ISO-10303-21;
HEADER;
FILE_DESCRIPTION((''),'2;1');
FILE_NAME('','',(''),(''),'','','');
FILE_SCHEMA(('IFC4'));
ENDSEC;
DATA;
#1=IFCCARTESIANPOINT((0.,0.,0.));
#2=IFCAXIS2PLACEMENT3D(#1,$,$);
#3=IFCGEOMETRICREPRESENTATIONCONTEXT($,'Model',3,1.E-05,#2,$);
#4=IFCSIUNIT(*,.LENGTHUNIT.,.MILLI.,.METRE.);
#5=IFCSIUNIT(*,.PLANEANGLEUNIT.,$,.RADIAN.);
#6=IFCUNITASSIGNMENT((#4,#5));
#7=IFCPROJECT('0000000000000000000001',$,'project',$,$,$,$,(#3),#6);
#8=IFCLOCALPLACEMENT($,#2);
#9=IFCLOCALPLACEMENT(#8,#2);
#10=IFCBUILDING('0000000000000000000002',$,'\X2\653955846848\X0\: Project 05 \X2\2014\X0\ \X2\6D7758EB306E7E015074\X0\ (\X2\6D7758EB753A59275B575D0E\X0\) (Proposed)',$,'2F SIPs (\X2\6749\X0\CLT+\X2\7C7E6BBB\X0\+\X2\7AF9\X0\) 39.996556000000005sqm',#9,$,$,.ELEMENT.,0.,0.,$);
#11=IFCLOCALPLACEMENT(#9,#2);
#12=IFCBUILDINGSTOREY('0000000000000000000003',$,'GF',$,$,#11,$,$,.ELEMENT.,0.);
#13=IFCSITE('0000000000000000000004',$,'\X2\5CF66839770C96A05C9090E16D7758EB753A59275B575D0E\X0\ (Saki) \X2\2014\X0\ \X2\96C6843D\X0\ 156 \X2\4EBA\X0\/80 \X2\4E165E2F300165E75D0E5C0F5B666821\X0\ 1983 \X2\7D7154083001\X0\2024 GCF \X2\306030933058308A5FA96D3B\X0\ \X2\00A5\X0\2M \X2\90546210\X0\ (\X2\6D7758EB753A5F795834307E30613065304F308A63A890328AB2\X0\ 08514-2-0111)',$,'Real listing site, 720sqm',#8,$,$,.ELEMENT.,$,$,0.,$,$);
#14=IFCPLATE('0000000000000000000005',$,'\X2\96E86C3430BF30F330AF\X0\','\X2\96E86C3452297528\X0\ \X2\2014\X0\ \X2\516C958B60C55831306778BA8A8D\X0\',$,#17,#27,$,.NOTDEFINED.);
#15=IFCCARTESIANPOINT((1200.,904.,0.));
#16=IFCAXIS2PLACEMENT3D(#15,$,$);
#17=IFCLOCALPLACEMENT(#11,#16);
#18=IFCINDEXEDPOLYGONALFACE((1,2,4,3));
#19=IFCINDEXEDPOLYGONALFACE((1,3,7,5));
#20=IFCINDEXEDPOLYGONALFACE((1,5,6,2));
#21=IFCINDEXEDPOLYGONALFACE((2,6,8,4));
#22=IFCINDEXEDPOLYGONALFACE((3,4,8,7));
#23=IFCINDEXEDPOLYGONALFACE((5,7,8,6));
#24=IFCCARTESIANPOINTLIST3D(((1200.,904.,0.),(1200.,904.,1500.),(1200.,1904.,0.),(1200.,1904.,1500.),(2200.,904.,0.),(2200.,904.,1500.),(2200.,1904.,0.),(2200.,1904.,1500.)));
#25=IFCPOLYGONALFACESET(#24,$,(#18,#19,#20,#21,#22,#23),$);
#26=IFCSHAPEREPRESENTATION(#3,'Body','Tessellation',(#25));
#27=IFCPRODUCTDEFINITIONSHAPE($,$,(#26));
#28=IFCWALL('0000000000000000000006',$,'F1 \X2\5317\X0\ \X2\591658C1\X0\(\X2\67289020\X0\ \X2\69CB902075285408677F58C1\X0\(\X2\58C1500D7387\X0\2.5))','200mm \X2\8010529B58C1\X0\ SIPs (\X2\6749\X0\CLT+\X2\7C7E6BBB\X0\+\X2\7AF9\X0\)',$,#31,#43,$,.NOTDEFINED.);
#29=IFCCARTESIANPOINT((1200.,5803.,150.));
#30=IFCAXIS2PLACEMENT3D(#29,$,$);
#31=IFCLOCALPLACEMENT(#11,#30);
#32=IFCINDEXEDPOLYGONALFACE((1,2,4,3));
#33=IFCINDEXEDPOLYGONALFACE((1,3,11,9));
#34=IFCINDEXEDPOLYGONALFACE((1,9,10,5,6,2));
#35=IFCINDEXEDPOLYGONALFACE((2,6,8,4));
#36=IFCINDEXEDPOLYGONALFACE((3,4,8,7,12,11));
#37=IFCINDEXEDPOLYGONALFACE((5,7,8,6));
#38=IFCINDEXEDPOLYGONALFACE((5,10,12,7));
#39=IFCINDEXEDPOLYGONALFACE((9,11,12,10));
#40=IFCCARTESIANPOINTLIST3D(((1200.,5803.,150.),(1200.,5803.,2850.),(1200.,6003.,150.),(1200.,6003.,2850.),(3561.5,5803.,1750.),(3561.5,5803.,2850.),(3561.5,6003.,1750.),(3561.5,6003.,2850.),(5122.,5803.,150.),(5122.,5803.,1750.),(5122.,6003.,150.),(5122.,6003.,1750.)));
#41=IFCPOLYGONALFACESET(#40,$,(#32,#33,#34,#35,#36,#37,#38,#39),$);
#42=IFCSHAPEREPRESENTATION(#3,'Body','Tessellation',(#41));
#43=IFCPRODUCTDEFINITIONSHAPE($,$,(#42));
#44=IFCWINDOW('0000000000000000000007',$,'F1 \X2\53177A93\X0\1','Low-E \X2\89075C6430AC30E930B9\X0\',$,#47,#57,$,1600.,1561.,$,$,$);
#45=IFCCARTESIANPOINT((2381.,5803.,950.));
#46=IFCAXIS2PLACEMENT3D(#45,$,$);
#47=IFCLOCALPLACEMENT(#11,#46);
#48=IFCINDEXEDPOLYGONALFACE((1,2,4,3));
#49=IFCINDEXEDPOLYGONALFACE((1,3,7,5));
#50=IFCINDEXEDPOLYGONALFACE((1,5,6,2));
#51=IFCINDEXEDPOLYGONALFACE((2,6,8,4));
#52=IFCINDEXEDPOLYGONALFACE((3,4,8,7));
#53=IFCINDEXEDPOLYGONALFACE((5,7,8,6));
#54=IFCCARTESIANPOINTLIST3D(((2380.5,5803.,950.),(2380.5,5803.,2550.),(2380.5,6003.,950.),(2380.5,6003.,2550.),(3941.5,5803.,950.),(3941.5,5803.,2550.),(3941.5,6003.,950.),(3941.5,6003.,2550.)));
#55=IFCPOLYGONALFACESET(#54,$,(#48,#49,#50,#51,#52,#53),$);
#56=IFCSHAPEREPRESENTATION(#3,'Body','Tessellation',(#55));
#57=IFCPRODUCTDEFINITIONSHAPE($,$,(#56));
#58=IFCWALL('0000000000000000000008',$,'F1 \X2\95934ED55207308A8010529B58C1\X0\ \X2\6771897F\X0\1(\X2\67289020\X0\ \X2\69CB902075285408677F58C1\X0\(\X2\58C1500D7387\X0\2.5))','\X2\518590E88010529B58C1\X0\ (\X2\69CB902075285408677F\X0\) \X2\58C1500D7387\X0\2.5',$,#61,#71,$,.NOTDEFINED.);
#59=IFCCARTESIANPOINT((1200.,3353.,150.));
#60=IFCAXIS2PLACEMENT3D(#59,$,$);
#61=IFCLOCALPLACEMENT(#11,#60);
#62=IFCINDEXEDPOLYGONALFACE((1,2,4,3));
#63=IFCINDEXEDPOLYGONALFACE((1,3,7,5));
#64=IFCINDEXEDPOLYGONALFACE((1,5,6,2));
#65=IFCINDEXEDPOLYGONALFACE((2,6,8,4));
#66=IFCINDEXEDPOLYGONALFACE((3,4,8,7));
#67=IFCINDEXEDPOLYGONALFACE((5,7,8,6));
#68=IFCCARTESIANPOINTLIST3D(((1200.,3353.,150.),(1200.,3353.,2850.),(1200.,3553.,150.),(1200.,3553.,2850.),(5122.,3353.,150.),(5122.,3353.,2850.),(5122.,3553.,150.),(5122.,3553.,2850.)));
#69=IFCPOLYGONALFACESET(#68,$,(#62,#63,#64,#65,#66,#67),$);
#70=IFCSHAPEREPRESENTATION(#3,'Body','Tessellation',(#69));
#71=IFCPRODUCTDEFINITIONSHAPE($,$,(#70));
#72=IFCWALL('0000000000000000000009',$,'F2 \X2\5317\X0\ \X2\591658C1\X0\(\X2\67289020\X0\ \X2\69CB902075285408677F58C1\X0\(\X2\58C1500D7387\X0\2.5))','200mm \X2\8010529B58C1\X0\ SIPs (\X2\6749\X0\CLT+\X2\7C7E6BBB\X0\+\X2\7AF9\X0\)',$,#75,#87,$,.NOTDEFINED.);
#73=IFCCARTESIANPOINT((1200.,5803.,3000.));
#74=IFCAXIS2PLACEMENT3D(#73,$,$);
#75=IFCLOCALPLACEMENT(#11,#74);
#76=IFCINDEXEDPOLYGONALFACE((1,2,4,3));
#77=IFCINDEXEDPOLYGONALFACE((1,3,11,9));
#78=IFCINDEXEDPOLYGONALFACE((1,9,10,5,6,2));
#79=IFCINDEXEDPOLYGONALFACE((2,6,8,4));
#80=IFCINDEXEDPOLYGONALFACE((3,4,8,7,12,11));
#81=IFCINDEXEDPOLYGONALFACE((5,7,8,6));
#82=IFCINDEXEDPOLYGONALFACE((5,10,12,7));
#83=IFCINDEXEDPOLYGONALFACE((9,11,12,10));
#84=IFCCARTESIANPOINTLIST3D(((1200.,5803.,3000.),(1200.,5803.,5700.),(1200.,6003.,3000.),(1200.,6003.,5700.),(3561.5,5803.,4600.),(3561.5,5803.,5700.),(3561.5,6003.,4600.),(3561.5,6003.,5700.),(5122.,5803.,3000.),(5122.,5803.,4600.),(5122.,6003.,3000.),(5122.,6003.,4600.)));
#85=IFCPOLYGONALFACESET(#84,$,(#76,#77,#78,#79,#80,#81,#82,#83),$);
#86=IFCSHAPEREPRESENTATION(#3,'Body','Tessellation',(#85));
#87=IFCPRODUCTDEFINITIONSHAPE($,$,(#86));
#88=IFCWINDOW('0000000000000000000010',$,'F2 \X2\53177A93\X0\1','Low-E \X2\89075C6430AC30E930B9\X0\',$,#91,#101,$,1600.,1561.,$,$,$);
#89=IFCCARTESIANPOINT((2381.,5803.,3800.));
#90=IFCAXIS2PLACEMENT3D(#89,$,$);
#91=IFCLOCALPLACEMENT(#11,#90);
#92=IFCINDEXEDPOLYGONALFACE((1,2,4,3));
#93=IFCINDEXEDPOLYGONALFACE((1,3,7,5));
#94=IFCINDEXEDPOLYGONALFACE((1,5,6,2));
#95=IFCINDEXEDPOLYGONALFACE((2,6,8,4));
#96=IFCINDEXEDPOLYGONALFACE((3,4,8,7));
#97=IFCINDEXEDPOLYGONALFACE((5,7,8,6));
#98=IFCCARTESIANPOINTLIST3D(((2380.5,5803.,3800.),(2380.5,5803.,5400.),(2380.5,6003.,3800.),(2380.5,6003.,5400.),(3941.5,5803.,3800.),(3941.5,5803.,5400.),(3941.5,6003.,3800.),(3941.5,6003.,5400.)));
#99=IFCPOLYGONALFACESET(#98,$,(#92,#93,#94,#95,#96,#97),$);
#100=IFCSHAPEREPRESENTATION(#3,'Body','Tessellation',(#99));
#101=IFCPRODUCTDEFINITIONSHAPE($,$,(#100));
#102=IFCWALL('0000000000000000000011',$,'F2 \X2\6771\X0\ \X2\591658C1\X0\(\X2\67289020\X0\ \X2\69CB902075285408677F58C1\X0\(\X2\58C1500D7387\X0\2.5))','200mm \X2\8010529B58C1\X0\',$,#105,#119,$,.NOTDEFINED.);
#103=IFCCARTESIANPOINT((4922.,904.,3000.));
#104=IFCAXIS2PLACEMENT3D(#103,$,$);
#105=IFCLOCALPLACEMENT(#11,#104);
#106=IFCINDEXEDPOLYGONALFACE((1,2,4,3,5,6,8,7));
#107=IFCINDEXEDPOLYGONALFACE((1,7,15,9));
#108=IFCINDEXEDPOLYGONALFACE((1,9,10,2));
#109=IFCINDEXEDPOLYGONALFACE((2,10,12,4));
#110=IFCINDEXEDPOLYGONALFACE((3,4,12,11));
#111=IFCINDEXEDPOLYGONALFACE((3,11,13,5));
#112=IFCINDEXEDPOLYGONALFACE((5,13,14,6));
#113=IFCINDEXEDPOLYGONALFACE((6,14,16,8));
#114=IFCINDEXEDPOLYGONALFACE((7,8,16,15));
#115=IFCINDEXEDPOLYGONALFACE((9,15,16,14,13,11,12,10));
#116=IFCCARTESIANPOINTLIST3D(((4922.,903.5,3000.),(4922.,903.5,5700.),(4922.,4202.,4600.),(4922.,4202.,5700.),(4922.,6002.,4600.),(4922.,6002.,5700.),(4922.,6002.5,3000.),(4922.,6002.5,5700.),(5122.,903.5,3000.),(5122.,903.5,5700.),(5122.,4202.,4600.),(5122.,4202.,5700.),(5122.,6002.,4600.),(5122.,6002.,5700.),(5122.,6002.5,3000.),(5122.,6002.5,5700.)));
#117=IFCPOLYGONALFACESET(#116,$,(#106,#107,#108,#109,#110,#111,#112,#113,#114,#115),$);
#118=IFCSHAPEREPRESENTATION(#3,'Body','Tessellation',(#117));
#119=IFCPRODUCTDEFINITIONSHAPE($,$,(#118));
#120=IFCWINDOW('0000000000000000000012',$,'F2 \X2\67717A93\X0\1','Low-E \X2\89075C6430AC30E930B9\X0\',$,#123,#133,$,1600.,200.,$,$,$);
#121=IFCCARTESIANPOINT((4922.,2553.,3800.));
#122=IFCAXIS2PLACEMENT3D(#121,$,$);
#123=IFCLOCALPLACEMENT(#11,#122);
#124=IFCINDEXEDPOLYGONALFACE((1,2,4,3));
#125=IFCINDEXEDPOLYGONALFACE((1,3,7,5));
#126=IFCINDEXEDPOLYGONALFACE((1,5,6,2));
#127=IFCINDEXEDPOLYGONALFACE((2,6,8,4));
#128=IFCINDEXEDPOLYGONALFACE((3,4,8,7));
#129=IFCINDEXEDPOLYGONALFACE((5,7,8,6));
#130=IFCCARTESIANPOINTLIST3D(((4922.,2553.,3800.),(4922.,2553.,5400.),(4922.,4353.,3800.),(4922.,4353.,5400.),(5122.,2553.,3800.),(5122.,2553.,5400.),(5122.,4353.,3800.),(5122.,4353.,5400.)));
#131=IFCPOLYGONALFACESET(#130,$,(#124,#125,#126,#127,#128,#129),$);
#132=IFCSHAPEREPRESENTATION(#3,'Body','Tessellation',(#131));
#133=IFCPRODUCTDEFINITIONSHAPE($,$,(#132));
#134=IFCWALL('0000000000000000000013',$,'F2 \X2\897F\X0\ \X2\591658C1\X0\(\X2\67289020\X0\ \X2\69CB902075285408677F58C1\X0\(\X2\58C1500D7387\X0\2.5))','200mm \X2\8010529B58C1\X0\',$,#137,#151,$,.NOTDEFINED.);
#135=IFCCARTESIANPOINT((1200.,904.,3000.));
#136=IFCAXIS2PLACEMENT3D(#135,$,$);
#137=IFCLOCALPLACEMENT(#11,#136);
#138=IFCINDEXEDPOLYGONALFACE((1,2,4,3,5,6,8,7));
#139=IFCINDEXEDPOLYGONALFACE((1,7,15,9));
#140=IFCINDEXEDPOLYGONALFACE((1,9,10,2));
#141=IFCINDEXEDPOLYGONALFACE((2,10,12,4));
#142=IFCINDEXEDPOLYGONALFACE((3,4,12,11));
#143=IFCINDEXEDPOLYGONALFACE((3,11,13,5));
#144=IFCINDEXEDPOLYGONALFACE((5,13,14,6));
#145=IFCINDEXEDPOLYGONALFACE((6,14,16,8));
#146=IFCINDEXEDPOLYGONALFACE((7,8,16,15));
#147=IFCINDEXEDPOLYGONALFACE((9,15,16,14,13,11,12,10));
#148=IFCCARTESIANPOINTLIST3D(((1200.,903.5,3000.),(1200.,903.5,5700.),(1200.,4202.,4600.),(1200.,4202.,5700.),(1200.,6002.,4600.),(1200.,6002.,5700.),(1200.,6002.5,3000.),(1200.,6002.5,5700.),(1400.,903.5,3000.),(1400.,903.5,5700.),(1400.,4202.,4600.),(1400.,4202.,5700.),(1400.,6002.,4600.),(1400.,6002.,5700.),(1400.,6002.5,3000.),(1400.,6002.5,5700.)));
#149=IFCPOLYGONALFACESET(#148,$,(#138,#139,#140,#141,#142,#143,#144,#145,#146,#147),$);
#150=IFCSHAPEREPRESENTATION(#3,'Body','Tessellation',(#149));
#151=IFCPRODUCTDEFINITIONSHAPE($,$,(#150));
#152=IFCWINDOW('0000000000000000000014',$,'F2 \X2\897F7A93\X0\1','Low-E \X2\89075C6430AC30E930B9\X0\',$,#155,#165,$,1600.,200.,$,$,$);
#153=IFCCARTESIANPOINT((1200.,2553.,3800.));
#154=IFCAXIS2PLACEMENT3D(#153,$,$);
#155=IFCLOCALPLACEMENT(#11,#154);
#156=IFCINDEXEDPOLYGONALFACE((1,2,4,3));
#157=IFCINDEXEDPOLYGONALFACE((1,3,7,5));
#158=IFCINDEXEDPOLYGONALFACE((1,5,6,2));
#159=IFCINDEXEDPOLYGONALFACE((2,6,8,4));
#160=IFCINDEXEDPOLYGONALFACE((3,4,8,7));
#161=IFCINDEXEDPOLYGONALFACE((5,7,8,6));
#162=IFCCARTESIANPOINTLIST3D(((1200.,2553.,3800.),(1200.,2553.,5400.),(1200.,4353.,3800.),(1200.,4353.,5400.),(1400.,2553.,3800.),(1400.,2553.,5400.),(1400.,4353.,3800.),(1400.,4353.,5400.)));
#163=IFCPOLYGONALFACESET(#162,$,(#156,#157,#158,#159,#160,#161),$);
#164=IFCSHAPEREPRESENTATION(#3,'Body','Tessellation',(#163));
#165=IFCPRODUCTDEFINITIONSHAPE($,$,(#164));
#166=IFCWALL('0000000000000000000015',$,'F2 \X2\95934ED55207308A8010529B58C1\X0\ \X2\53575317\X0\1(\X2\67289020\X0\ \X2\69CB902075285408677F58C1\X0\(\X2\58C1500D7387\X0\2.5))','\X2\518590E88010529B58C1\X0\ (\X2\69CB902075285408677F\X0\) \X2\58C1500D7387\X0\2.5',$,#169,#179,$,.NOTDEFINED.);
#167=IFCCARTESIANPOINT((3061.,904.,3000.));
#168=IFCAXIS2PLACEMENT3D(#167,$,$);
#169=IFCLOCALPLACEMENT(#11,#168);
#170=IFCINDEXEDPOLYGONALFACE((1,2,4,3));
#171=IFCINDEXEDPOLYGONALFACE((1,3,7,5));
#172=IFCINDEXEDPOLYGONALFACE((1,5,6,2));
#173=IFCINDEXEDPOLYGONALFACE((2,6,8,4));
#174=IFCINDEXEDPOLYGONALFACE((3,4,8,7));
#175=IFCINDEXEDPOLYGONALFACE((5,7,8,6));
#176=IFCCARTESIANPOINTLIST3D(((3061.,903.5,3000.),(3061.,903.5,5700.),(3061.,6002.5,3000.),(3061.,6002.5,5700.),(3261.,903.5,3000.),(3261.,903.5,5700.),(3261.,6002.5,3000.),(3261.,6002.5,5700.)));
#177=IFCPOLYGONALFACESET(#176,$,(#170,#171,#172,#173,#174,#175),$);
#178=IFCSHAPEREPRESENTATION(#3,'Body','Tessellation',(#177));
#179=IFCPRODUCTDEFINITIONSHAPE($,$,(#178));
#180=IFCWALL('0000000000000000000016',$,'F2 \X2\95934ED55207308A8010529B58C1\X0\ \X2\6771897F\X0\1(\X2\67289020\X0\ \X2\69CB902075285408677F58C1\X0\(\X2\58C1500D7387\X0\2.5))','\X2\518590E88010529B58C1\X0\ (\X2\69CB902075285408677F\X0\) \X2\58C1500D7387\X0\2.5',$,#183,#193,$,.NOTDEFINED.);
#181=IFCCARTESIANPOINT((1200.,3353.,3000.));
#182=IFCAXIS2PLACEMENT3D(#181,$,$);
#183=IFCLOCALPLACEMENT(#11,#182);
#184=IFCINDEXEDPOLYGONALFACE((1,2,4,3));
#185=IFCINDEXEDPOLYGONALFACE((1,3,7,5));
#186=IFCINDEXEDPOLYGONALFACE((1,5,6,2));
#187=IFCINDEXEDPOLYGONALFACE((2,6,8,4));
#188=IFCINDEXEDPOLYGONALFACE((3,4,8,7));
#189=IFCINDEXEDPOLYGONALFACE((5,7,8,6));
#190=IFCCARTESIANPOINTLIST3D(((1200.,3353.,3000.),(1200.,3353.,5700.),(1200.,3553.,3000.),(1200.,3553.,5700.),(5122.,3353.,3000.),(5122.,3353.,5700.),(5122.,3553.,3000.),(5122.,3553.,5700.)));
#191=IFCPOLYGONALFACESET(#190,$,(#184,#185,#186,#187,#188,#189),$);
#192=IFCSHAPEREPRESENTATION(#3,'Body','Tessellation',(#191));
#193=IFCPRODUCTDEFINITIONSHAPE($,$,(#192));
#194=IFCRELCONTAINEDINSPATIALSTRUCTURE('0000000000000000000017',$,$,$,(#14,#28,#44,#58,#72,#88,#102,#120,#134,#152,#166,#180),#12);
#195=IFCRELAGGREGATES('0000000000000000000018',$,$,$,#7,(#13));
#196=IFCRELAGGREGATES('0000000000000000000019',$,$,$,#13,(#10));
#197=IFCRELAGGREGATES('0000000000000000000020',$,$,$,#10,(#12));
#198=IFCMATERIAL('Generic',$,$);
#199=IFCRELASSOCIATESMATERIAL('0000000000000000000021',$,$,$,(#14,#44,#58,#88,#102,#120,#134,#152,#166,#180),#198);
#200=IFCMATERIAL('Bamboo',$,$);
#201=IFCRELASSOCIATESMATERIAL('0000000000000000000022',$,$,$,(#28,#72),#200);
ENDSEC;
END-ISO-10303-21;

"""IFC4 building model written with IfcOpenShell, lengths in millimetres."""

from ifc_helpers import new_model, si_unit, frame, frame_2d, origin, place, context, project, spatial, rectangle, extrude, material, element, fill, save


model = new_model("IFC4")

# Units and contexts
model_context = context("Model", 3, precision=1e-05, world=origin())
ifc_project = project(units=[si_unit("LENGTHUNIT", "METRE", prefix="MILLI"), si_unit("PLANEANGLEUNIT", "RADIAN")], contexts=[model_context])

# Site, building, storey
site_placement = place(None, origin())
site = spatial("IfcSite", under=ifc_project, at=site_placement, Name="島根県隠岐郡海士町大字崎 (Saki) — 集落 156 人/80 世帯、旧崎小学校 1983 統合、2024 GCF だんじり復活 ¥2M 達成 (海士町役場まちづくり推進課 08514-2-0111)", ObjectType="Real listing site, 720sqm", CompositionType="ELEMENT", RefElevation=0.0)
building_placement = place(site_placement, origin())
building = spatial("IfcBuilding", under=site, at=building_placement, Name="改善案: Project 05 — 海士の縁側 (海士町大字崎) (Proposed)", ObjectType="2F SIPs (杉CLT+籾殻+竹) 39.996556000000005sqm", CompositionType="ELEMENT", ElevationOfRefHeight=0.0, ElevationOfTerrain=0.0)
storey_placement = place(building_placement, origin())
storey = spatial("IfcBuildingStorey", under=building, at=storey_placement, Name="GF", CompositionType="ELEMENT", Elevation=0.0)

# Plate
ifc_material_1 = material(Name="Generic")
plate_placement = place(storey_placement, frame((1200.0, 904.0, 0.0)))
element("IfcPlate", 1, at=plate_placement, inside=storey, material=ifc_material_1, Name="雨水タンク", Description="雨水利用 — 公開情報で確認", PredefinedType="NOTDEFINED", context=model_context, shape_type="SweptSolid", body=[
    extrude(rectangle(XDim=1000.0, YDim=1000.0, at=frame_2d((500.0, 500.0))), frame((1200.0, 904.0, 0.0)), (0.0, 0.0, 1.0), 1500.0),
])

# Wall, opening, window
ifc_material_2 = material(Name="Bamboo")
wall_1_placement = place(storey_placement, frame((1200.0, 5803.0, 150.0)))
wall_1 = element("IfcWall", 2, at=wall_1_placement, inside=storey, material=ifc_material_2, Name="F1 北 外壁(木造 構造用合板壁(壁倍率2.5))", Description="200mm 耐力壁 SIPs (杉CLT+籾殻+竹)", PredefinedType="NOTDEFINED", context=model_context, shape_type="SweptSolid", body=[
    extrude(rectangle(XDim=3922.0, YDim=200.0, at=frame_2d((1961.0, 100.0))), frame((1200.0, 5803.0, 150.0)), (0.0, 0.0, 1.0), 2700.0),
])
opening_1_placement = place(storey_placement, frame((2381.0, 5803.0, 950.0)))
opening_1 = element("IfcOpeningElement", 3, at=opening_1_placement, cuts=wall_1, PredefinedType="NOTDEFINED", context=model_context, shape_type="SweptSolid", body=[
    extrude(rectangle(XDim=1561.0, YDim=200.0, at=frame_2d((780.0, 100.0))), frame((2381.0, 5803.0, 950.0)), (0.0, 0.0, 1.0), 1600.0),
])
window_1_placement = place(storey_placement, frame((2381.0, 5803.0, 950.0)))
window_1 = element("IfcWindow", 4, at=window_1_placement, inside=storey, material=ifc_material_1, Name="F1 北窓1", Description="Low-E 複層ガラス", OverallHeight=1600.0, OverallWidth=1561.0, context=model_context, shape_type="SweptSolid", body=[
    extrude(rectangle(XDim=1561.0, YDim=200.0, at=frame_2d((780.0, 100.0))), frame((2381.0, 5803.0, 950.0)), (0.0, 0.0, 1.0), 1600.0),
])
fill(opening_1, window_1)

# Wall
wall_2_placement = place(storey_placement, frame((1200.0, 3353.0, 150.0)))
element("IfcWall", 5, at=wall_2_placement, inside=storey, material=ifc_material_1, Name="F1 間仕切り耐力壁 東西1(木造 構造用合板壁(壁倍率2.5))", Description="内部耐力壁 (構造用合板) 壁倍率2.5", PredefinedType="NOTDEFINED", context=model_context, shape_type="SweptSolid", body=[
    extrude(rectangle(XDim=3922.0, YDim=200.0, at=frame_2d((1961.0, 100.0))), frame((1200.0, 3353.0, 150.0)), (0.0, 0.0, 1.0), 2700.0),
])

# Walls, openings, windows
wall_3_placement = place(storey_placement, frame((1200.0, 5803.0, 3000.0)))
wall_3 = element("IfcWall", 6, at=wall_3_placement, inside=storey, material=ifc_material_2, Name="F2 北 外壁(木造 構造用合板壁(壁倍率2.5))", Description="200mm 耐力壁 SIPs (杉CLT+籾殻+竹)", PredefinedType="NOTDEFINED", context=model_context, shape_type="SweptSolid", body=[
    extrude(rectangle(XDim=3922.0, YDim=200.0, at=frame_2d((1961.0, 100.0))), frame((1200.0, 5803.0, 3000.0)), (0.0, 0.0, 1.0), 2700.0),
])
opening_2_placement = place(storey_placement, frame((2381.0, 5803.0, 3800.0)))
opening_2 = element("IfcOpeningElement", 7, at=opening_2_placement, cuts=wall_3, PredefinedType="NOTDEFINED", context=model_context, shape_type="SweptSolid", body=[
    extrude(rectangle(XDim=1561.0, YDim=200.0, at=frame_2d((780.0, 100.0))), frame((2381.0, 5803.0, 3800.0)), (0.0, 0.0, 1.0), 1600.0),
])
window_2_placement = place(storey_placement, frame((2381.0, 5803.0, 3800.0)))
window_2 = element("IfcWindow", 8, at=window_2_placement, inside=storey, material=ifc_material_1, Name="F2 北窓1", Description="Low-E 複層ガラス", OverallHeight=1600.0, OverallWidth=1561.0, context=model_context, shape_type="SweptSolid", body=[
    extrude(rectangle(XDim=1561.0, YDim=200.0, at=frame_2d((780.0, 100.0))), frame((2381.0, 5803.0, 3800.0)), (0.0, 0.0, 1.0), 1600.0),
])
fill(opening_2, window_2)
wall_4_placement = place(storey_placement, frame((4922.0, 904.0, 3000.0)))
wall_4 = element("IfcWall", 9, at=wall_4_placement, inside=storey, material=ifc_material_1, Name="F2 東 外壁(木造 構造用合板壁(壁倍率2.5))", Description="200mm 耐力壁", PredefinedType="NOTDEFINED", context=model_context, shape_type="SweptSolid", body=[
    extrude(rectangle(XDim=200.0, YDim=5099.0, at=frame_2d((100.0, 2549.0))), frame((4922.0, 904.0, 3000.0)), (0.0, 0.0, 1.0), 2700.0),
])
opening_3_placement = place(storey_placement, frame((4922.0, 2553.0, 3800.0)))
opening_3 = element("IfcOpeningElement", 10, at=opening_3_placement, cuts=wall_4, PredefinedType="NOTDEFINED", context=model_context, shape_type="SweptSolid", body=[
    extrude(rectangle(XDim=200.0, YDim=1800.0, at=frame_2d((100.0, 900.0))), frame((4922.0, 2553.0, 3800.0)), (0.0, 0.0, 1.0), 1600.0),
])
window_3_placement = place(storey_placement, frame((4922.0, 2553.0, 3800.0)))
window_3 = element("IfcWindow", 11, at=window_3_placement, inside=storey, material=ifc_material_1, Name="F2 東窓1", Description="Low-E 複層ガラス", OverallHeight=1600.0, OverallWidth=200.0, context=model_context, shape_type="SweptSolid", body=[
    extrude(rectangle(XDim=200.0, YDim=1800.0, at=frame_2d((100.0, 900.0))), frame((4922.0, 2553.0, 3800.0)), (0.0, 0.0, 1.0), 1600.0),
])
fill(opening_3, window_3)
wall_5_placement = place(storey_placement, frame((1200.0, 904.0, 3000.0)))
wall_5 = element("IfcWall", 12, at=wall_5_placement, inside=storey, material=ifc_material_1, Name="F2 西 外壁(木造 構造用合板壁(壁倍率2.5))", Description="200mm 耐力壁", PredefinedType="NOTDEFINED", context=model_context, shape_type="SweptSolid", body=[
    extrude(rectangle(XDim=200.0, YDim=5099.0, at=frame_2d((100.0, 2549.0))), frame((1200.0, 904.0, 3000.0)), (0.0, 0.0, 1.0), 2700.0),
])
opening_4_placement = place(storey_placement, frame((1200.0, 2553.0, 3800.0)))
opening_4 = element("IfcOpeningElement", 13, at=opening_4_placement, cuts=wall_5, PredefinedType="NOTDEFINED", context=model_context, shape_type="SweptSolid", body=[
    extrude(rectangle(XDim=200.0, YDim=1800.0, at=frame_2d((100.0, 900.0))), frame((1200.0, 2553.0, 3800.0)), (0.0, 0.0, 1.0), 1600.0),
])
window_4_placement = place(storey_placement, frame((1200.0, 2553.0, 3800.0)))
window_4 = element("IfcWindow", 14, at=window_4_placement, inside=storey, material=ifc_material_1, Name="F2 西窓1", Description="Low-E 複層ガラス", OverallHeight=1600.0, OverallWidth=200.0, context=model_context, shape_type="SweptSolid", body=[
    extrude(rectangle(XDim=200.0, YDim=1800.0, at=frame_2d((100.0, 900.0))), frame((1200.0, 2553.0, 3800.0)), (0.0, 0.0, 1.0), 1600.0),
])
fill(opening_4, window_4)

# Walls
wall_6_placement = place(storey_placement, frame((3061.0, 904.0, 3000.0)))
element("IfcWall", 15, at=wall_6_placement, inside=storey, material=ifc_material_1, Name="F2 間仕切り耐力壁 南北1(木造 構造用合板壁(壁倍率2.5))", Description="内部耐力壁 (構造用合板) 壁倍率2.5", PredefinedType="NOTDEFINED", context=model_context, shape_type="SweptSolid", body=[
    extrude(rectangle(XDim=200.0, YDim=5099.0, at=frame_2d((100.0, 2549.0))), frame((3061.0, 904.0, 3000.0)), (0.0, 0.0, 1.0), 2700.0),
])
wall_7_placement = place(storey_placement, frame((1200.0, 3353.0, 3000.0)))
element("IfcWall", 16, at=wall_7_placement, inside=storey, material=ifc_material_1, Name="F2 間仕切り耐力壁 東西1(木造 構造用合板壁(壁倍率2.5))", Description="内部耐力壁 (構造用合板) 壁倍率2.5", PredefinedType="NOTDEFINED", context=model_context, shape_type="SweptSolid", body=[
    extrude(rectangle(XDim=3922.0, YDim=200.0, at=frame_2d((1961.0, 100.0))), frame((1200.0, 3353.0, 3000.0)), (0.0, 0.0, 1.0), 2700.0),
])

save(model, "model.ifc")
